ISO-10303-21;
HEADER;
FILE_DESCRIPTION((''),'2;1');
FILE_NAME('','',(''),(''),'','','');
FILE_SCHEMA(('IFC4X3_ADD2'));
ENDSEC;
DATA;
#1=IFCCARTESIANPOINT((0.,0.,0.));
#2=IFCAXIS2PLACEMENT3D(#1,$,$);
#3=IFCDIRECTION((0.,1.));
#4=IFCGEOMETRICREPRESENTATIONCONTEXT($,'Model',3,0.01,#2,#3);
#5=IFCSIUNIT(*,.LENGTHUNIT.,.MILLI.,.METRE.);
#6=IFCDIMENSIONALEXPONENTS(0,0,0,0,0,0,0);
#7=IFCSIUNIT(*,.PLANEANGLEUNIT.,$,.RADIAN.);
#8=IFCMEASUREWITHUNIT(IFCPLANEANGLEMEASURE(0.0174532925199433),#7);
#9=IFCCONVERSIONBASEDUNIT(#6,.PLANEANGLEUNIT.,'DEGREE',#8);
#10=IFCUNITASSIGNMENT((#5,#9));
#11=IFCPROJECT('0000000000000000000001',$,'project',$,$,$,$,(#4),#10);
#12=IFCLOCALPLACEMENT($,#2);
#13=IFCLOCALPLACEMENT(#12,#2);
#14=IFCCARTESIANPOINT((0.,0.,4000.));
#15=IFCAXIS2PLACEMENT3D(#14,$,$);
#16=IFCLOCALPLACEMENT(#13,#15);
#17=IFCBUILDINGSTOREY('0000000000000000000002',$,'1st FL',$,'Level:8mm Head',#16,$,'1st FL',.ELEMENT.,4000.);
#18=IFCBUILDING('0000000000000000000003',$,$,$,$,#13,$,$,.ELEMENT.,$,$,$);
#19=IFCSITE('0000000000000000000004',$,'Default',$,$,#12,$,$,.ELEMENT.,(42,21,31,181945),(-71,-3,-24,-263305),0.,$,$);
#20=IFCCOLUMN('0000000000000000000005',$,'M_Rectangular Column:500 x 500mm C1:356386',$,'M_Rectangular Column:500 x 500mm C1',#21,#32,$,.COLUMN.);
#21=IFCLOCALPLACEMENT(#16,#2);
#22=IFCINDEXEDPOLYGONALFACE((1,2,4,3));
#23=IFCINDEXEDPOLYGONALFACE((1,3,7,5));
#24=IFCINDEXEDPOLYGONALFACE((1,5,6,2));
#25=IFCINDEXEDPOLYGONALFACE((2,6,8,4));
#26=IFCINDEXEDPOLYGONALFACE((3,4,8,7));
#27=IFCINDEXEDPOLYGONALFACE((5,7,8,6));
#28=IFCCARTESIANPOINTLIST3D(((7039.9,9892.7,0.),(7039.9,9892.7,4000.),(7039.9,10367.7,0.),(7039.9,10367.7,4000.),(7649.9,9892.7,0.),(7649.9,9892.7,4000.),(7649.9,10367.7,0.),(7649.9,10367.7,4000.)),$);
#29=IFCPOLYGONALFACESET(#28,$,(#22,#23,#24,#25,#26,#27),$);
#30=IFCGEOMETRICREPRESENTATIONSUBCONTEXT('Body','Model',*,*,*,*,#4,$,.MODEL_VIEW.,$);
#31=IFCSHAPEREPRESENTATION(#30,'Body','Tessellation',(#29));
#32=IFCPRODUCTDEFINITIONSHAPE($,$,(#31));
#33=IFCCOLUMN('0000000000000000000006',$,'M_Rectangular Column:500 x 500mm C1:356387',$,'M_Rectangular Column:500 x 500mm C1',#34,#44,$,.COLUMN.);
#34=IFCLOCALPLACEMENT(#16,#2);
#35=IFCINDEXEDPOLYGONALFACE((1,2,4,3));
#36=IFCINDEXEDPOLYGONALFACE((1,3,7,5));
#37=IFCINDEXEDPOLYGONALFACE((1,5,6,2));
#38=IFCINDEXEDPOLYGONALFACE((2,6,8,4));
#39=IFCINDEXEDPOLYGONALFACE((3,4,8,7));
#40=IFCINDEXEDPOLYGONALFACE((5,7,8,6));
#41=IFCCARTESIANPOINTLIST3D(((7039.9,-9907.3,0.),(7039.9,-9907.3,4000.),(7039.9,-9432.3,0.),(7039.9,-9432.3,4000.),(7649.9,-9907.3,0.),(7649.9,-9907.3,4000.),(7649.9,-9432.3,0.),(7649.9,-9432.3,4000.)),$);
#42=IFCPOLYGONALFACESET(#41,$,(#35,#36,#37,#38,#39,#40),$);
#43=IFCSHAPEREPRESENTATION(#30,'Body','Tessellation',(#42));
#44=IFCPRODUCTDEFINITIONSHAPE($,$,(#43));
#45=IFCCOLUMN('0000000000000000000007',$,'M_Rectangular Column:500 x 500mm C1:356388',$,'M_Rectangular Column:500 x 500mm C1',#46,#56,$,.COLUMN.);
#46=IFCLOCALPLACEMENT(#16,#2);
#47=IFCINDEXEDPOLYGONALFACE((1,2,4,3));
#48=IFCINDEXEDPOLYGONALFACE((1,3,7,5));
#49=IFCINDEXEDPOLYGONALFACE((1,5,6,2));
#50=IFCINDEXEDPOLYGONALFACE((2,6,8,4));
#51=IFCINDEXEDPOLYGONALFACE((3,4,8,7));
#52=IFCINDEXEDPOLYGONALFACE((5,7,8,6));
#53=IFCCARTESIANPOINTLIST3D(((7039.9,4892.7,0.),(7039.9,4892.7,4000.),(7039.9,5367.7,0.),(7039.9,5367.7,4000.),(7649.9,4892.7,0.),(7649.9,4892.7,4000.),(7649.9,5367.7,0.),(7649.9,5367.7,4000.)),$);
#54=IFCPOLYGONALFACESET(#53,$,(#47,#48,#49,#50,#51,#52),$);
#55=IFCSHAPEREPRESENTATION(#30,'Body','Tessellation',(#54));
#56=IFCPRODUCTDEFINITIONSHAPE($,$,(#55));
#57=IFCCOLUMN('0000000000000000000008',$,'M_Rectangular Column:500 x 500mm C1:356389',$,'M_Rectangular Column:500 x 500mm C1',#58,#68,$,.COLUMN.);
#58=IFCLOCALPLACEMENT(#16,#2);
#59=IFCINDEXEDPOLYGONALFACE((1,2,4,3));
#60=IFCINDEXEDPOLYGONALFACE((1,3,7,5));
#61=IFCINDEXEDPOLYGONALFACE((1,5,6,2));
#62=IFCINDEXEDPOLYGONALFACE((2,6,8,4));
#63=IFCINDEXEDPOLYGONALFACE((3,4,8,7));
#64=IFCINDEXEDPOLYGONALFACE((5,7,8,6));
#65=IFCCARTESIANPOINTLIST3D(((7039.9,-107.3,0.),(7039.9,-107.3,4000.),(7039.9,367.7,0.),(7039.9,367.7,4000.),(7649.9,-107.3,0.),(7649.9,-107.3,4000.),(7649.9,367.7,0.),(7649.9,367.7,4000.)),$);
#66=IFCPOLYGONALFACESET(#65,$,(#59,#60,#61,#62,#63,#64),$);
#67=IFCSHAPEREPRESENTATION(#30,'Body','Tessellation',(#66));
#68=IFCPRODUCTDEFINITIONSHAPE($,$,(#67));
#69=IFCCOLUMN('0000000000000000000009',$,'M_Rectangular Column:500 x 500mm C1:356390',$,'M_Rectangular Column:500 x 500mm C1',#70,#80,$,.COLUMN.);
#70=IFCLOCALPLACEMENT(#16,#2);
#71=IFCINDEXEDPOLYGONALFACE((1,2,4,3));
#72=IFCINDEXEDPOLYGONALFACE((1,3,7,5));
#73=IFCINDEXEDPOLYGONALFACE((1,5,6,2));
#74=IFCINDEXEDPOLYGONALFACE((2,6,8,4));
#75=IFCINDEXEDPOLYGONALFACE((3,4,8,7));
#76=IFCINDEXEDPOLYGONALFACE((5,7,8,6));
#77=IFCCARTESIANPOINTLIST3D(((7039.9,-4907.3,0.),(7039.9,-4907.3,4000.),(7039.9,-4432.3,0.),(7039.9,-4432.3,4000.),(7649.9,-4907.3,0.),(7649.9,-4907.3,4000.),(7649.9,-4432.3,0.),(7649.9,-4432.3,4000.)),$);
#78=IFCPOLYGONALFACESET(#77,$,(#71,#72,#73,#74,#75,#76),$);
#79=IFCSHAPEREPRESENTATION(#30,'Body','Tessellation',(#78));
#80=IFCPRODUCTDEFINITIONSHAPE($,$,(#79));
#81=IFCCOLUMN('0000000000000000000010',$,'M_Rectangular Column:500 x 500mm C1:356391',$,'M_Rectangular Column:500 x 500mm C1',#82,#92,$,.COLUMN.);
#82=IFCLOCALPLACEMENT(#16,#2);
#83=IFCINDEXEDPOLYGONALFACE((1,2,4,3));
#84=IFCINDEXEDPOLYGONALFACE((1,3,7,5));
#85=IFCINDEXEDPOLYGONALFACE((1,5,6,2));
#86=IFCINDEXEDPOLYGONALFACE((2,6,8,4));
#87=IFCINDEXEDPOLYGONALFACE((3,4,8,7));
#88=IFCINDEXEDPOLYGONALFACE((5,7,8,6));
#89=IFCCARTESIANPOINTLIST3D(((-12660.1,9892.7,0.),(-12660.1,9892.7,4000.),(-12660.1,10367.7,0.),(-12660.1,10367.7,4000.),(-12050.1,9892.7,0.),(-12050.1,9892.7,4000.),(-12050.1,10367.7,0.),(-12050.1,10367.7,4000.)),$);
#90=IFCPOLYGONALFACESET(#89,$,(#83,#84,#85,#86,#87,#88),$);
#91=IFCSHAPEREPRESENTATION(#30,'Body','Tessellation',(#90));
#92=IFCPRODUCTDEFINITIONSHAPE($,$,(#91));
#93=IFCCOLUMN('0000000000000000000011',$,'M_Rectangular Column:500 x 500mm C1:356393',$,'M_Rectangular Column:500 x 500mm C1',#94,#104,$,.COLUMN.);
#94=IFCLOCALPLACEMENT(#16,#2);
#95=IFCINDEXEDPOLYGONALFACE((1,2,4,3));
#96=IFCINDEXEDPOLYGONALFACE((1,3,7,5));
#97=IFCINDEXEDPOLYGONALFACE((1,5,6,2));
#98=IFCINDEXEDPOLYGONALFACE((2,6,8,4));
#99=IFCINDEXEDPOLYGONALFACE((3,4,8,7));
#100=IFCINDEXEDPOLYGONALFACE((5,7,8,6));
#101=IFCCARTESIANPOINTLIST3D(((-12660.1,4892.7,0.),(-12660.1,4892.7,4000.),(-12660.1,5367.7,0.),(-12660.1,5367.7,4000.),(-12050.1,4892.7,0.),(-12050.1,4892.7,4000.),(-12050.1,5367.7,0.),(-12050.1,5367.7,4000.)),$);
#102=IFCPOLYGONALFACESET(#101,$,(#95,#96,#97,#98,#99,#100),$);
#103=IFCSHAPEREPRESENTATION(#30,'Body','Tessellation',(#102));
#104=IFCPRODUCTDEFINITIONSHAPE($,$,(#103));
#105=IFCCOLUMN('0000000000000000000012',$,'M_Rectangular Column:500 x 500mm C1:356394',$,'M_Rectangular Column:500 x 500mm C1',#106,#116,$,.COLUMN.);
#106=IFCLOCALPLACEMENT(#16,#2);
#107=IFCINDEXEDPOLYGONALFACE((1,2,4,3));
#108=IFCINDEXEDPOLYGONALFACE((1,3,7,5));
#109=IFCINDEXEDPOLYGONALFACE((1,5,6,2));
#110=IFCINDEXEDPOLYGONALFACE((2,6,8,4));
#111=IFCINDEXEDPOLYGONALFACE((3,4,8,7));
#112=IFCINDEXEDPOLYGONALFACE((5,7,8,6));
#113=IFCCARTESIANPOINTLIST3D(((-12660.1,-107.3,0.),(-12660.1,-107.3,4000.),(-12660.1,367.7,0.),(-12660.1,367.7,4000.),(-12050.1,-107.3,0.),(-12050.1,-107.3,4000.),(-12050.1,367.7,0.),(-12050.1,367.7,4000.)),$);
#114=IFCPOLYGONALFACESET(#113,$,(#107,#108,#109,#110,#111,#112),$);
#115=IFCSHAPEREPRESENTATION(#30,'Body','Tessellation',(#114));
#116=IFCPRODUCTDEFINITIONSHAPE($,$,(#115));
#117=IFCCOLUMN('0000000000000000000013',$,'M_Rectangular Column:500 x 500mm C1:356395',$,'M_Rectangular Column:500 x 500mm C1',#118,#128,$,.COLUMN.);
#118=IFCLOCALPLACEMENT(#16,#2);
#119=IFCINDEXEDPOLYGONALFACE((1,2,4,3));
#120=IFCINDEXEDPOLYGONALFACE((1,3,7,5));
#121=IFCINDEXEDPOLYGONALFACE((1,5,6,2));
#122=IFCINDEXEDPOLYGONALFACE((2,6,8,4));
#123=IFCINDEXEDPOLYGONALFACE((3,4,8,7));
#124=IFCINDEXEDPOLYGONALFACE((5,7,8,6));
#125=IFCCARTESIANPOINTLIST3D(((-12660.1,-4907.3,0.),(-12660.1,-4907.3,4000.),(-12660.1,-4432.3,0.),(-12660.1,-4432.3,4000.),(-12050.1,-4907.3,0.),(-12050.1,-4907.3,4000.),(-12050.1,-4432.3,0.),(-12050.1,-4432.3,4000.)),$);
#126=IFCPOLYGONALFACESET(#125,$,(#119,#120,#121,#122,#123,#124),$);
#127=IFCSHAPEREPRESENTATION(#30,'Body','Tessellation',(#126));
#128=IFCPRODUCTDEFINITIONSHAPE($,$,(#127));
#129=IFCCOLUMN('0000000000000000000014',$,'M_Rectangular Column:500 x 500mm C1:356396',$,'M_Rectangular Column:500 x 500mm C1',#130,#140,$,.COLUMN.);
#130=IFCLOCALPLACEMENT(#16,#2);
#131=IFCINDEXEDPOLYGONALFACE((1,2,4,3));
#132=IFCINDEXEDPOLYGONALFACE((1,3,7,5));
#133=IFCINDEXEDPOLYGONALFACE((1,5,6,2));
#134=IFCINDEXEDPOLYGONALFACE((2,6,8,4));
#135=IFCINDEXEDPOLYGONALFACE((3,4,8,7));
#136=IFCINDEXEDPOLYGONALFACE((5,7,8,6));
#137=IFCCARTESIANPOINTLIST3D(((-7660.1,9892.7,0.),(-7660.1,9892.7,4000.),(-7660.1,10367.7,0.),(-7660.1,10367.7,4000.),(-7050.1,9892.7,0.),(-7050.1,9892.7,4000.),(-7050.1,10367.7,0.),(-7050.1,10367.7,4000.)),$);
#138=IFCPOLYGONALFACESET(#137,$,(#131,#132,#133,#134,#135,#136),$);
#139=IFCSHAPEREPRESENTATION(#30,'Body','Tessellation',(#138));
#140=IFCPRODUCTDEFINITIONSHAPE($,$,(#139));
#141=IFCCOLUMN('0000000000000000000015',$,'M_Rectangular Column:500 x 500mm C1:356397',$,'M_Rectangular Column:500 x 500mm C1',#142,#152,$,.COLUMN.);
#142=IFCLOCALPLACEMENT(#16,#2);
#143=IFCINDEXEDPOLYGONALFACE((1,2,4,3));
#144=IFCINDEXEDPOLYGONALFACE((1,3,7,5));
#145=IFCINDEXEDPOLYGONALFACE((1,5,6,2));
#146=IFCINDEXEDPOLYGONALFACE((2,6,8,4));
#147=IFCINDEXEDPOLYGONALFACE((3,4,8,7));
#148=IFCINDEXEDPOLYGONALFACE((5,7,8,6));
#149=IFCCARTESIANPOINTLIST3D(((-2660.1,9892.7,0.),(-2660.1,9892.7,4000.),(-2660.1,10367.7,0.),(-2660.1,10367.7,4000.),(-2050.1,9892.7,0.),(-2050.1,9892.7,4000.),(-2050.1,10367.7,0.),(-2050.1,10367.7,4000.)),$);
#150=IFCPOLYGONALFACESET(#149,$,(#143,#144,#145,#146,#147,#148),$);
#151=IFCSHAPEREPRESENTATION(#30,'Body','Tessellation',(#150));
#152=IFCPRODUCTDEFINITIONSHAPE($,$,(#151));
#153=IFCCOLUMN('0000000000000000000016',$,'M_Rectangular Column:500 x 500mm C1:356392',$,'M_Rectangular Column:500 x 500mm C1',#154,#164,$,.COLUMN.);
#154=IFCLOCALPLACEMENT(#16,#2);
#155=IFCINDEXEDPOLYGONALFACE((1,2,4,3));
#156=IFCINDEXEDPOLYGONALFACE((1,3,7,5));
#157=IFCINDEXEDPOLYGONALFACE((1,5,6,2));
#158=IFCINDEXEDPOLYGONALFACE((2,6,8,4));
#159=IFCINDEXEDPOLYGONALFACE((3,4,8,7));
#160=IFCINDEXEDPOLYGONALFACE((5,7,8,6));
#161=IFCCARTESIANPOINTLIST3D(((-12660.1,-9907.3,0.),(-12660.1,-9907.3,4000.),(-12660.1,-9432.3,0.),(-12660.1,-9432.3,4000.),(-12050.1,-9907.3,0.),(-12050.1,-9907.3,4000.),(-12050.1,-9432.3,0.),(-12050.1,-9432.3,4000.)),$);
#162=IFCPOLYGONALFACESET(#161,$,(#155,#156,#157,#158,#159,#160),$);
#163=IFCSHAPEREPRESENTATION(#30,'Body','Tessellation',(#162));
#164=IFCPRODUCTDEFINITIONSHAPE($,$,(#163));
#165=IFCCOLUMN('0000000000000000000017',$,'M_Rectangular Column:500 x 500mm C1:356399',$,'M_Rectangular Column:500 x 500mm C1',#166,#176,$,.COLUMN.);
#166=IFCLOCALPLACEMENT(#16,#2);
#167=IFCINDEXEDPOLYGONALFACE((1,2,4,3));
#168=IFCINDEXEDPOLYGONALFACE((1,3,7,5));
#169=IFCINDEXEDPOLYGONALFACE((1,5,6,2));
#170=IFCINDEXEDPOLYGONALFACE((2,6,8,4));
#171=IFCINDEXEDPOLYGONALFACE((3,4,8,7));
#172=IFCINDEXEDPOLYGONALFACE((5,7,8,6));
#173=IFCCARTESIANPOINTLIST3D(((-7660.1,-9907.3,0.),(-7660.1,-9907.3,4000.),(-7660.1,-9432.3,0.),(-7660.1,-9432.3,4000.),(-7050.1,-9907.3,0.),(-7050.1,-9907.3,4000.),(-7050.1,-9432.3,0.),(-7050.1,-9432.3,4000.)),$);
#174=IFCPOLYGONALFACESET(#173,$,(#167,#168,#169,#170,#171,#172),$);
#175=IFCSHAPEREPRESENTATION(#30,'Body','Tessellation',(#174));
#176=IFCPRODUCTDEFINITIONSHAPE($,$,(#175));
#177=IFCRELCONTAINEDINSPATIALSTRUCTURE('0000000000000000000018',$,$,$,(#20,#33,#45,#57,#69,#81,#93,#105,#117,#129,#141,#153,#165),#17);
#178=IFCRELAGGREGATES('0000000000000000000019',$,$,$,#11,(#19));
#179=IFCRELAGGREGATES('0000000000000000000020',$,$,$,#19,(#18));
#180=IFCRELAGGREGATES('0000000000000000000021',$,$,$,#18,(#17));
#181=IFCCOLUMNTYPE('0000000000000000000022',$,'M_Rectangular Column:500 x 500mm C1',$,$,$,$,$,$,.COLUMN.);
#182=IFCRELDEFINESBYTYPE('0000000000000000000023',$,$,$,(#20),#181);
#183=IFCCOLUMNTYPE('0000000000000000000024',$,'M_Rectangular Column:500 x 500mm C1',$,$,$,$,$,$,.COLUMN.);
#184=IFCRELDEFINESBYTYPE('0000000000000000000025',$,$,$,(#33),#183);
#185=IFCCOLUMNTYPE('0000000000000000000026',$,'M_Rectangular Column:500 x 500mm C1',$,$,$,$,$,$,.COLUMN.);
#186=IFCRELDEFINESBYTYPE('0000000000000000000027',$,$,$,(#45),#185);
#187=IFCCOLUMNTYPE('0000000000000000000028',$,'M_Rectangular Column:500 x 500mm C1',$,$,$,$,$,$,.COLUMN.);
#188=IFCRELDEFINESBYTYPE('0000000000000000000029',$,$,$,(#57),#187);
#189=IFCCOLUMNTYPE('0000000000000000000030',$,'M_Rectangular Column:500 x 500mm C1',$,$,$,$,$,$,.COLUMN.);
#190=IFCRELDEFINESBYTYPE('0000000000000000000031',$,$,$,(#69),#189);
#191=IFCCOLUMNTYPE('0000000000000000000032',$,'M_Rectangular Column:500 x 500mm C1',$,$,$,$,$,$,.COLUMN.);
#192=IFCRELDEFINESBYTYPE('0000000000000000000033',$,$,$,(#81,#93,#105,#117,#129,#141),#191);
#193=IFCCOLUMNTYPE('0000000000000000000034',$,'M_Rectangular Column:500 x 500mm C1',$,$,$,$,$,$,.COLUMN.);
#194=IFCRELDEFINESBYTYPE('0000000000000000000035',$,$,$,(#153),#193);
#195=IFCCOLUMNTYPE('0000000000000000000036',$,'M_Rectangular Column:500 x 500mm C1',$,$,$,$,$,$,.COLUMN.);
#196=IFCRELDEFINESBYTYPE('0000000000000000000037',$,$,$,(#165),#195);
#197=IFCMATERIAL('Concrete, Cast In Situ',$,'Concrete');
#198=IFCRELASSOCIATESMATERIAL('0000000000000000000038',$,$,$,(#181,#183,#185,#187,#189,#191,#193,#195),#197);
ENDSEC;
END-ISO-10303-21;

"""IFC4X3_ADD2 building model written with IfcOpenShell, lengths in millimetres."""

from ifc_helpers import new_model, entity, si_unit, converted_unit, direction, frame, frame_2d, origin, origin_2d_with_axis, place, context, subcontext, project, spatial, rectangle, extrude, source, transform, mapped, material, material_profile, profile_set, type_object, type_shapes, element, save


model = new_model("IFC4X3_ADD2")

# Units and contexts
model_context = context("Model", 3, precision=0.01, world=origin(), true_north=direction((0.0, 1.0)))
body_context = subcontext(model_context, "Body", "Model", "MODEL_VIEW")
ifc_project = project(units=[si_unit("LENGTHUNIT", "METRE", prefix="MILLI"), converted_unit("PLANEANGLEUNIT", "DEGREE", entity("IfcPlaneAngleMeasure", 0.0174532925199433), si_unit("PLANEANGLEUNIT", "RADIAN"), dimensions=[0, 0, 0, 0, 0, 0, 0])], contexts=[model_context])

# Site, building, storey
site_placement = place(None, origin())
site = spatial("IfcSite", under=ifc_project, at=site_placement, Name="Default", CompositionType="ELEMENT", RefLatitude=(42, 21, 31, 181945), RefLongitude=(-71, -3, -24, -263305), RefElevation=0.0)
building_placement = place(site_placement, origin())
building = spatial("IfcBuilding", under=site, at=building_placement, CompositionType="ELEMENT")
storey_placement = place(building_placement, frame((0.0, 0.0, 4000.0)))
storey = spatial("IfcBuildingStorey", under=building, at=storey_placement, Name="1st FL", ObjectType="Level:8mm Head", LongName="1st FL", CompositionType="ELEMENT", Elevation=4000.0)

# Columns
ifc_material_1 = material(Name="Concrete, Cast In Situ", Category="Concrete")
ifc_material_profile_1 = material_profile(ifc_material_1, rectangle(XDim=610.0, YDim=475.0, at=frame_2d((0.0, 0.0), x_axis=(1.0, 0.0))), Name="500 x 500mm C1")
ifc_profile_set_1 = profile_set([ifc_material_profile_1], Name="500 x 500mm C1")
column_type_1 = type_object("IfcColumnType", Name="M_Rectangular Column:500 x 500mm C1", PredefinedType="COLUMN", material=ifc_profile_set_1)
shared_shape_1 = source(origin(), body_context, "Body", "SweptSolid", [
    extrude(rectangle(XDim=610.0, YDim=475.0, at=frame_2d((0.0, 0.0), x_axis=(1.0, 0.0))), frame((7344.9, 10130.2, 4000.0), z_axis=(0.0, 0.0, 1.0), x_axis=(-1.0, 0.0, 0.0)), (0.0, 0.0, 1.0), 4000.0),
])
type_shapes(column_type_1, [shared_shape_1])
column_1_placement = place(storey_placement, frame((0.0, 0.0, -4000.0)))
element("IfcColumn", 1, at=column_1_placement, inside=storey, type_object=column_type_1, Name="M_Rectangular Column:500 x 500mm C1:356386", ObjectType="M_Rectangular Column:500 x 500mm C1", PredefinedType="COLUMN", context=body_context, shape_type="MappedRepresentation", body=[
    mapped(shared_shape_1, transform((0.0, 0.0, 0.0), scale=1.0)),
])
column_type_2 = type_object("IfcColumnType", Name="M_Rectangular Column:500 x 500mm C1", PredefinedType="COLUMN", material=ifc_profile_set_1)
shared_shape_2 = source(origin(), body_context, "Body", "SweptSolid", [
    extrude(rectangle(XDim=610.0, YDim=475.0, at=origin_2d_with_axis()), frame((7344.9, -9669.8, 4000.0), z_axis=(0.0, 0.0, 1.0), x_axis=(-1.0, 0.0, 0.0)), (0.0, 0.0, 1.0), 4000.0),
])
type_shapes(column_type_2, [shared_shape_2])
column_2_placement = place(storey_placement, frame((0.0, 0.0, -4000.0)))
element("IfcColumn", 2, at=column_2_placement, inside=storey, type_object=column_type_2, Name="M_Rectangular Column:500 x 500mm C1:356387", ObjectType="M_Rectangular Column:500 x 500mm C1", PredefinedType="COLUMN", context=body_context, shape_type="MappedRepresentation", body=[
    mapped(shared_shape_2, transform((0.0, 0.0, 0.0), scale=1.0)),
])
column_type_3 = type_object("IfcColumnType", Name="M_Rectangular Column:500 x 500mm C1", PredefinedType="COLUMN", material=ifc_profile_set_1)
shared_shape_3 = source(origin(), body_context, "Body", "SweptSolid", [
    extrude(rectangle(XDim=610.0, YDim=475.0, at=frame_2d((0.0, 0.0), x_axis=(1.0, 0.0))), frame((7344.9, 5130.2, 4000.0), z_axis=(0.0, 0.0, 1.0), x_axis=(-1.0, 0.0, 0.0)), (0.0, 0.0, 1.0), 4000.0),
])
type_shapes(column_type_3, [shared_shape_3])
column_3_placement = place(storey_placement, frame((0.0, 0.0, -4000.0)))
element("IfcColumn", 3, at=column_3_placement, inside=storey, type_object=column_type_3, Name="M_Rectangular Column:500 x 500mm C1:356388", ObjectType="M_Rectangular Column:500 x 500mm C1", PredefinedType="COLUMN", context=body_context, shape_type="MappedRepresentation", body=[
    mapped(shared_shape_3, transform((0.0, 0.0, 0.0), scale=1.0)),
])
column_type_4 = type_object("IfcColumnType", Name="M_Rectangular Column:500 x 500mm C1", PredefinedType="COLUMN", material=ifc_profile_set_1)
shared_shape_4 = source(origin(), body_context, "Body", "SweptSolid", [
    extrude(rectangle(XDim=610.0, YDim=475.0, at=origin_2d_with_axis()), frame((7344.9, 130.2, 4000.0), z_axis=(0.0, 0.0, 1.0), x_axis=(-1.0, 0.0, 0.0)), (0.0, 0.0, 1.0), 4000.0),
])
type_shapes(column_type_4, [shared_shape_4])
column_4_placement = place(storey_placement, frame((0.0, 0.0, -4000.0)))
element("IfcColumn", 4, at=column_4_placement, inside=storey, type_object=column_type_4, Name="M_Rectangular Column:500 x 500mm C1:356389", ObjectType="M_Rectangular Column:500 x 500mm C1", PredefinedType="COLUMN", context=body_context, shape_type="MappedRepresentation", body=[
    mapped(shared_shape_4, transform((0.0, 0.0, 0.0), scale=1.0)),
])
column_type_5 = type_object("IfcColumnType", Name="M_Rectangular Column:500 x 500mm C1", PredefinedType="COLUMN", material=ifc_profile_set_1)
shared_shape_5 = source(origin(), body_context, "Body", "SweptSolid", [
    extrude(rectangle(XDim=610.0, YDim=475.0, at=origin_2d_with_axis()), frame((7344.9, -4669.8, 4000.0), z_axis=(0.0, 0.0, 1.0), x_axis=(-1.0, 0.0, 0.0)), (0.0, 0.0, 1.0), 4000.0),
])
type_shapes(column_type_5, [shared_shape_5])
column_5_placement = place(storey_placement, frame((0.0, 0.0, -4000.0)))
element("IfcColumn", 5, at=column_5_placement, inside=storey, type_object=column_type_5, Name="M_Rectangular Column:500 x 500mm C1:356390", ObjectType="M_Rectangular Column:500 x 500mm C1", PredefinedType="COLUMN", context=body_context, shape_type="MappedRepresentation", body=[
    mapped(shared_shape_5, transform((0.0, 0.0, 0.0), scale=1.0)),
])
column_type_6 = type_object("IfcColumnType", Name="M_Rectangular Column:500 x 500mm C1", PredefinedType="COLUMN", material=ifc_profile_set_1)
shared_shape_6 = source(origin(), body_context, "Body", "SweptSolid", [
    extrude(rectangle(XDim=610.0, YDim=475.0, at=origin_2d_with_axis()), frame((0.0, 0.0, 4000.0), z_axis=(0.0, 0.0, 1.0), x_axis=(-1.0, 0.0, 0.0)), (0.0, 0.0, 1.0), 4000.0),
])
type_shapes(column_type_6, [shared_shape_6])
for number, where, name in (
    (6, (-12355.1, 10130.2, -4000.0), "M_Rectangular Column:500 x 500mm C1:356391"),
    (7, (-12355.1, 5130.2, -4000.0), "M_Rectangular Column:500 x 500mm C1:356393"),
    (8, (-12355.1, 130.2, -4000.0), "M_Rectangular Column:500 x 500mm C1:356394"),
    (9, (-12355.1, -4669.8, -4000.0), "M_Rectangular Column:500 x 500mm C1:356395"),
    (10, (-7355.1, 10130.2, -4000.0), "M_Rectangular Column:500 x 500mm C1:356396"),
    (11, (-2355.1, 10130.2, -4000.0), "M_Rectangular Column:500 x 500mm C1:356397"),
):
    element("IfcColumn", number, at=place(storey_placement, frame(where)), inside=storey, type_object=column_type_6, Name=name, ObjectType="M_Rectangular Column:500 x 500mm C1", PredefinedType="COLUMN", context=body_context, shape_type="MappedRepresentation", body=[
        mapped(shared_shape_6, transform((0.0, 0.0, 0.0), scale=1.0)),
    ])
column_type_7 = type_object("IfcColumnType", Name="M_Rectangular Column:500 x 500mm C1", PredefinedType="COLUMN", material=ifc_profile_set_1)
shared_shape_7 = source(origin(), body_context, "Body", "SweptSolid", [
    extrude(rectangle(XDim=610.0, YDim=475.0, at=frame_2d((0.0, 0.0), x_axis=(1.0, 0.0))), frame((-12355.1, -9669.8, 4000.0), z_axis=(0.0, 0.0, 1.0), x_axis=(-1.0, 0.0, 0.0)), (0.0, 0.0, 1.0), 4000.0),
])
type_shapes(column_type_7, [shared_shape_7])
column_6_placement = place(storey_placement, frame((0.0, 0.0, -4000.0)))
element("IfcColumn", 12, at=column_6_placement, inside=storey, type_object=column_type_7, Name="M_Rectangular Column:500 x 500mm C1:356392", ObjectType="M_Rectangular Column:500 x 500mm C1", PredefinedType="COLUMN", context=body_context, shape_type="MappedRepresentation", body=[
    mapped(shared_shape_7, transform((0.0, 0.0, 0.0), scale=1.0)),
])
column_type_8 = type_object("IfcColumnType", Name="M_Rectangular Column:500 x 500mm C1", PredefinedType="COLUMN", material=ifc_profile_set_1)
shared_shape_8 = source(origin(), body_context, "Body", "SweptSolid", [
    extrude(rectangle(XDim=610.0, YDim=475.0, at=origin_2d_with_axis()), frame((-7355.1, -9669.8, 4000.0), z_axis=(0.0, 0.0, 1.0), x_axis=(-1.0, 0.0, 0.0)), (0.0, 0.0, 1.0), 4000.0),
])
type_shapes(column_type_8, [shared_shape_8])
column_7_placement = place(storey_placement, frame((0.0, 0.0, -4000.0)))
element("IfcColumn", 13, at=column_7_placement, inside=storey, type_object=column_type_8, Name="M_Rectangular Column:500 x 500mm C1:356399", ObjectType="M_Rectangular Column:500 x 500mm C1", PredefinedType="COLUMN", context=body_context, shape_type="MappedRepresentation", body=[
    mapped(shared_shape_8, transform((0.0, 0.0, 0.0), scale=1.0)),
])

save(model, "model.ifc")
